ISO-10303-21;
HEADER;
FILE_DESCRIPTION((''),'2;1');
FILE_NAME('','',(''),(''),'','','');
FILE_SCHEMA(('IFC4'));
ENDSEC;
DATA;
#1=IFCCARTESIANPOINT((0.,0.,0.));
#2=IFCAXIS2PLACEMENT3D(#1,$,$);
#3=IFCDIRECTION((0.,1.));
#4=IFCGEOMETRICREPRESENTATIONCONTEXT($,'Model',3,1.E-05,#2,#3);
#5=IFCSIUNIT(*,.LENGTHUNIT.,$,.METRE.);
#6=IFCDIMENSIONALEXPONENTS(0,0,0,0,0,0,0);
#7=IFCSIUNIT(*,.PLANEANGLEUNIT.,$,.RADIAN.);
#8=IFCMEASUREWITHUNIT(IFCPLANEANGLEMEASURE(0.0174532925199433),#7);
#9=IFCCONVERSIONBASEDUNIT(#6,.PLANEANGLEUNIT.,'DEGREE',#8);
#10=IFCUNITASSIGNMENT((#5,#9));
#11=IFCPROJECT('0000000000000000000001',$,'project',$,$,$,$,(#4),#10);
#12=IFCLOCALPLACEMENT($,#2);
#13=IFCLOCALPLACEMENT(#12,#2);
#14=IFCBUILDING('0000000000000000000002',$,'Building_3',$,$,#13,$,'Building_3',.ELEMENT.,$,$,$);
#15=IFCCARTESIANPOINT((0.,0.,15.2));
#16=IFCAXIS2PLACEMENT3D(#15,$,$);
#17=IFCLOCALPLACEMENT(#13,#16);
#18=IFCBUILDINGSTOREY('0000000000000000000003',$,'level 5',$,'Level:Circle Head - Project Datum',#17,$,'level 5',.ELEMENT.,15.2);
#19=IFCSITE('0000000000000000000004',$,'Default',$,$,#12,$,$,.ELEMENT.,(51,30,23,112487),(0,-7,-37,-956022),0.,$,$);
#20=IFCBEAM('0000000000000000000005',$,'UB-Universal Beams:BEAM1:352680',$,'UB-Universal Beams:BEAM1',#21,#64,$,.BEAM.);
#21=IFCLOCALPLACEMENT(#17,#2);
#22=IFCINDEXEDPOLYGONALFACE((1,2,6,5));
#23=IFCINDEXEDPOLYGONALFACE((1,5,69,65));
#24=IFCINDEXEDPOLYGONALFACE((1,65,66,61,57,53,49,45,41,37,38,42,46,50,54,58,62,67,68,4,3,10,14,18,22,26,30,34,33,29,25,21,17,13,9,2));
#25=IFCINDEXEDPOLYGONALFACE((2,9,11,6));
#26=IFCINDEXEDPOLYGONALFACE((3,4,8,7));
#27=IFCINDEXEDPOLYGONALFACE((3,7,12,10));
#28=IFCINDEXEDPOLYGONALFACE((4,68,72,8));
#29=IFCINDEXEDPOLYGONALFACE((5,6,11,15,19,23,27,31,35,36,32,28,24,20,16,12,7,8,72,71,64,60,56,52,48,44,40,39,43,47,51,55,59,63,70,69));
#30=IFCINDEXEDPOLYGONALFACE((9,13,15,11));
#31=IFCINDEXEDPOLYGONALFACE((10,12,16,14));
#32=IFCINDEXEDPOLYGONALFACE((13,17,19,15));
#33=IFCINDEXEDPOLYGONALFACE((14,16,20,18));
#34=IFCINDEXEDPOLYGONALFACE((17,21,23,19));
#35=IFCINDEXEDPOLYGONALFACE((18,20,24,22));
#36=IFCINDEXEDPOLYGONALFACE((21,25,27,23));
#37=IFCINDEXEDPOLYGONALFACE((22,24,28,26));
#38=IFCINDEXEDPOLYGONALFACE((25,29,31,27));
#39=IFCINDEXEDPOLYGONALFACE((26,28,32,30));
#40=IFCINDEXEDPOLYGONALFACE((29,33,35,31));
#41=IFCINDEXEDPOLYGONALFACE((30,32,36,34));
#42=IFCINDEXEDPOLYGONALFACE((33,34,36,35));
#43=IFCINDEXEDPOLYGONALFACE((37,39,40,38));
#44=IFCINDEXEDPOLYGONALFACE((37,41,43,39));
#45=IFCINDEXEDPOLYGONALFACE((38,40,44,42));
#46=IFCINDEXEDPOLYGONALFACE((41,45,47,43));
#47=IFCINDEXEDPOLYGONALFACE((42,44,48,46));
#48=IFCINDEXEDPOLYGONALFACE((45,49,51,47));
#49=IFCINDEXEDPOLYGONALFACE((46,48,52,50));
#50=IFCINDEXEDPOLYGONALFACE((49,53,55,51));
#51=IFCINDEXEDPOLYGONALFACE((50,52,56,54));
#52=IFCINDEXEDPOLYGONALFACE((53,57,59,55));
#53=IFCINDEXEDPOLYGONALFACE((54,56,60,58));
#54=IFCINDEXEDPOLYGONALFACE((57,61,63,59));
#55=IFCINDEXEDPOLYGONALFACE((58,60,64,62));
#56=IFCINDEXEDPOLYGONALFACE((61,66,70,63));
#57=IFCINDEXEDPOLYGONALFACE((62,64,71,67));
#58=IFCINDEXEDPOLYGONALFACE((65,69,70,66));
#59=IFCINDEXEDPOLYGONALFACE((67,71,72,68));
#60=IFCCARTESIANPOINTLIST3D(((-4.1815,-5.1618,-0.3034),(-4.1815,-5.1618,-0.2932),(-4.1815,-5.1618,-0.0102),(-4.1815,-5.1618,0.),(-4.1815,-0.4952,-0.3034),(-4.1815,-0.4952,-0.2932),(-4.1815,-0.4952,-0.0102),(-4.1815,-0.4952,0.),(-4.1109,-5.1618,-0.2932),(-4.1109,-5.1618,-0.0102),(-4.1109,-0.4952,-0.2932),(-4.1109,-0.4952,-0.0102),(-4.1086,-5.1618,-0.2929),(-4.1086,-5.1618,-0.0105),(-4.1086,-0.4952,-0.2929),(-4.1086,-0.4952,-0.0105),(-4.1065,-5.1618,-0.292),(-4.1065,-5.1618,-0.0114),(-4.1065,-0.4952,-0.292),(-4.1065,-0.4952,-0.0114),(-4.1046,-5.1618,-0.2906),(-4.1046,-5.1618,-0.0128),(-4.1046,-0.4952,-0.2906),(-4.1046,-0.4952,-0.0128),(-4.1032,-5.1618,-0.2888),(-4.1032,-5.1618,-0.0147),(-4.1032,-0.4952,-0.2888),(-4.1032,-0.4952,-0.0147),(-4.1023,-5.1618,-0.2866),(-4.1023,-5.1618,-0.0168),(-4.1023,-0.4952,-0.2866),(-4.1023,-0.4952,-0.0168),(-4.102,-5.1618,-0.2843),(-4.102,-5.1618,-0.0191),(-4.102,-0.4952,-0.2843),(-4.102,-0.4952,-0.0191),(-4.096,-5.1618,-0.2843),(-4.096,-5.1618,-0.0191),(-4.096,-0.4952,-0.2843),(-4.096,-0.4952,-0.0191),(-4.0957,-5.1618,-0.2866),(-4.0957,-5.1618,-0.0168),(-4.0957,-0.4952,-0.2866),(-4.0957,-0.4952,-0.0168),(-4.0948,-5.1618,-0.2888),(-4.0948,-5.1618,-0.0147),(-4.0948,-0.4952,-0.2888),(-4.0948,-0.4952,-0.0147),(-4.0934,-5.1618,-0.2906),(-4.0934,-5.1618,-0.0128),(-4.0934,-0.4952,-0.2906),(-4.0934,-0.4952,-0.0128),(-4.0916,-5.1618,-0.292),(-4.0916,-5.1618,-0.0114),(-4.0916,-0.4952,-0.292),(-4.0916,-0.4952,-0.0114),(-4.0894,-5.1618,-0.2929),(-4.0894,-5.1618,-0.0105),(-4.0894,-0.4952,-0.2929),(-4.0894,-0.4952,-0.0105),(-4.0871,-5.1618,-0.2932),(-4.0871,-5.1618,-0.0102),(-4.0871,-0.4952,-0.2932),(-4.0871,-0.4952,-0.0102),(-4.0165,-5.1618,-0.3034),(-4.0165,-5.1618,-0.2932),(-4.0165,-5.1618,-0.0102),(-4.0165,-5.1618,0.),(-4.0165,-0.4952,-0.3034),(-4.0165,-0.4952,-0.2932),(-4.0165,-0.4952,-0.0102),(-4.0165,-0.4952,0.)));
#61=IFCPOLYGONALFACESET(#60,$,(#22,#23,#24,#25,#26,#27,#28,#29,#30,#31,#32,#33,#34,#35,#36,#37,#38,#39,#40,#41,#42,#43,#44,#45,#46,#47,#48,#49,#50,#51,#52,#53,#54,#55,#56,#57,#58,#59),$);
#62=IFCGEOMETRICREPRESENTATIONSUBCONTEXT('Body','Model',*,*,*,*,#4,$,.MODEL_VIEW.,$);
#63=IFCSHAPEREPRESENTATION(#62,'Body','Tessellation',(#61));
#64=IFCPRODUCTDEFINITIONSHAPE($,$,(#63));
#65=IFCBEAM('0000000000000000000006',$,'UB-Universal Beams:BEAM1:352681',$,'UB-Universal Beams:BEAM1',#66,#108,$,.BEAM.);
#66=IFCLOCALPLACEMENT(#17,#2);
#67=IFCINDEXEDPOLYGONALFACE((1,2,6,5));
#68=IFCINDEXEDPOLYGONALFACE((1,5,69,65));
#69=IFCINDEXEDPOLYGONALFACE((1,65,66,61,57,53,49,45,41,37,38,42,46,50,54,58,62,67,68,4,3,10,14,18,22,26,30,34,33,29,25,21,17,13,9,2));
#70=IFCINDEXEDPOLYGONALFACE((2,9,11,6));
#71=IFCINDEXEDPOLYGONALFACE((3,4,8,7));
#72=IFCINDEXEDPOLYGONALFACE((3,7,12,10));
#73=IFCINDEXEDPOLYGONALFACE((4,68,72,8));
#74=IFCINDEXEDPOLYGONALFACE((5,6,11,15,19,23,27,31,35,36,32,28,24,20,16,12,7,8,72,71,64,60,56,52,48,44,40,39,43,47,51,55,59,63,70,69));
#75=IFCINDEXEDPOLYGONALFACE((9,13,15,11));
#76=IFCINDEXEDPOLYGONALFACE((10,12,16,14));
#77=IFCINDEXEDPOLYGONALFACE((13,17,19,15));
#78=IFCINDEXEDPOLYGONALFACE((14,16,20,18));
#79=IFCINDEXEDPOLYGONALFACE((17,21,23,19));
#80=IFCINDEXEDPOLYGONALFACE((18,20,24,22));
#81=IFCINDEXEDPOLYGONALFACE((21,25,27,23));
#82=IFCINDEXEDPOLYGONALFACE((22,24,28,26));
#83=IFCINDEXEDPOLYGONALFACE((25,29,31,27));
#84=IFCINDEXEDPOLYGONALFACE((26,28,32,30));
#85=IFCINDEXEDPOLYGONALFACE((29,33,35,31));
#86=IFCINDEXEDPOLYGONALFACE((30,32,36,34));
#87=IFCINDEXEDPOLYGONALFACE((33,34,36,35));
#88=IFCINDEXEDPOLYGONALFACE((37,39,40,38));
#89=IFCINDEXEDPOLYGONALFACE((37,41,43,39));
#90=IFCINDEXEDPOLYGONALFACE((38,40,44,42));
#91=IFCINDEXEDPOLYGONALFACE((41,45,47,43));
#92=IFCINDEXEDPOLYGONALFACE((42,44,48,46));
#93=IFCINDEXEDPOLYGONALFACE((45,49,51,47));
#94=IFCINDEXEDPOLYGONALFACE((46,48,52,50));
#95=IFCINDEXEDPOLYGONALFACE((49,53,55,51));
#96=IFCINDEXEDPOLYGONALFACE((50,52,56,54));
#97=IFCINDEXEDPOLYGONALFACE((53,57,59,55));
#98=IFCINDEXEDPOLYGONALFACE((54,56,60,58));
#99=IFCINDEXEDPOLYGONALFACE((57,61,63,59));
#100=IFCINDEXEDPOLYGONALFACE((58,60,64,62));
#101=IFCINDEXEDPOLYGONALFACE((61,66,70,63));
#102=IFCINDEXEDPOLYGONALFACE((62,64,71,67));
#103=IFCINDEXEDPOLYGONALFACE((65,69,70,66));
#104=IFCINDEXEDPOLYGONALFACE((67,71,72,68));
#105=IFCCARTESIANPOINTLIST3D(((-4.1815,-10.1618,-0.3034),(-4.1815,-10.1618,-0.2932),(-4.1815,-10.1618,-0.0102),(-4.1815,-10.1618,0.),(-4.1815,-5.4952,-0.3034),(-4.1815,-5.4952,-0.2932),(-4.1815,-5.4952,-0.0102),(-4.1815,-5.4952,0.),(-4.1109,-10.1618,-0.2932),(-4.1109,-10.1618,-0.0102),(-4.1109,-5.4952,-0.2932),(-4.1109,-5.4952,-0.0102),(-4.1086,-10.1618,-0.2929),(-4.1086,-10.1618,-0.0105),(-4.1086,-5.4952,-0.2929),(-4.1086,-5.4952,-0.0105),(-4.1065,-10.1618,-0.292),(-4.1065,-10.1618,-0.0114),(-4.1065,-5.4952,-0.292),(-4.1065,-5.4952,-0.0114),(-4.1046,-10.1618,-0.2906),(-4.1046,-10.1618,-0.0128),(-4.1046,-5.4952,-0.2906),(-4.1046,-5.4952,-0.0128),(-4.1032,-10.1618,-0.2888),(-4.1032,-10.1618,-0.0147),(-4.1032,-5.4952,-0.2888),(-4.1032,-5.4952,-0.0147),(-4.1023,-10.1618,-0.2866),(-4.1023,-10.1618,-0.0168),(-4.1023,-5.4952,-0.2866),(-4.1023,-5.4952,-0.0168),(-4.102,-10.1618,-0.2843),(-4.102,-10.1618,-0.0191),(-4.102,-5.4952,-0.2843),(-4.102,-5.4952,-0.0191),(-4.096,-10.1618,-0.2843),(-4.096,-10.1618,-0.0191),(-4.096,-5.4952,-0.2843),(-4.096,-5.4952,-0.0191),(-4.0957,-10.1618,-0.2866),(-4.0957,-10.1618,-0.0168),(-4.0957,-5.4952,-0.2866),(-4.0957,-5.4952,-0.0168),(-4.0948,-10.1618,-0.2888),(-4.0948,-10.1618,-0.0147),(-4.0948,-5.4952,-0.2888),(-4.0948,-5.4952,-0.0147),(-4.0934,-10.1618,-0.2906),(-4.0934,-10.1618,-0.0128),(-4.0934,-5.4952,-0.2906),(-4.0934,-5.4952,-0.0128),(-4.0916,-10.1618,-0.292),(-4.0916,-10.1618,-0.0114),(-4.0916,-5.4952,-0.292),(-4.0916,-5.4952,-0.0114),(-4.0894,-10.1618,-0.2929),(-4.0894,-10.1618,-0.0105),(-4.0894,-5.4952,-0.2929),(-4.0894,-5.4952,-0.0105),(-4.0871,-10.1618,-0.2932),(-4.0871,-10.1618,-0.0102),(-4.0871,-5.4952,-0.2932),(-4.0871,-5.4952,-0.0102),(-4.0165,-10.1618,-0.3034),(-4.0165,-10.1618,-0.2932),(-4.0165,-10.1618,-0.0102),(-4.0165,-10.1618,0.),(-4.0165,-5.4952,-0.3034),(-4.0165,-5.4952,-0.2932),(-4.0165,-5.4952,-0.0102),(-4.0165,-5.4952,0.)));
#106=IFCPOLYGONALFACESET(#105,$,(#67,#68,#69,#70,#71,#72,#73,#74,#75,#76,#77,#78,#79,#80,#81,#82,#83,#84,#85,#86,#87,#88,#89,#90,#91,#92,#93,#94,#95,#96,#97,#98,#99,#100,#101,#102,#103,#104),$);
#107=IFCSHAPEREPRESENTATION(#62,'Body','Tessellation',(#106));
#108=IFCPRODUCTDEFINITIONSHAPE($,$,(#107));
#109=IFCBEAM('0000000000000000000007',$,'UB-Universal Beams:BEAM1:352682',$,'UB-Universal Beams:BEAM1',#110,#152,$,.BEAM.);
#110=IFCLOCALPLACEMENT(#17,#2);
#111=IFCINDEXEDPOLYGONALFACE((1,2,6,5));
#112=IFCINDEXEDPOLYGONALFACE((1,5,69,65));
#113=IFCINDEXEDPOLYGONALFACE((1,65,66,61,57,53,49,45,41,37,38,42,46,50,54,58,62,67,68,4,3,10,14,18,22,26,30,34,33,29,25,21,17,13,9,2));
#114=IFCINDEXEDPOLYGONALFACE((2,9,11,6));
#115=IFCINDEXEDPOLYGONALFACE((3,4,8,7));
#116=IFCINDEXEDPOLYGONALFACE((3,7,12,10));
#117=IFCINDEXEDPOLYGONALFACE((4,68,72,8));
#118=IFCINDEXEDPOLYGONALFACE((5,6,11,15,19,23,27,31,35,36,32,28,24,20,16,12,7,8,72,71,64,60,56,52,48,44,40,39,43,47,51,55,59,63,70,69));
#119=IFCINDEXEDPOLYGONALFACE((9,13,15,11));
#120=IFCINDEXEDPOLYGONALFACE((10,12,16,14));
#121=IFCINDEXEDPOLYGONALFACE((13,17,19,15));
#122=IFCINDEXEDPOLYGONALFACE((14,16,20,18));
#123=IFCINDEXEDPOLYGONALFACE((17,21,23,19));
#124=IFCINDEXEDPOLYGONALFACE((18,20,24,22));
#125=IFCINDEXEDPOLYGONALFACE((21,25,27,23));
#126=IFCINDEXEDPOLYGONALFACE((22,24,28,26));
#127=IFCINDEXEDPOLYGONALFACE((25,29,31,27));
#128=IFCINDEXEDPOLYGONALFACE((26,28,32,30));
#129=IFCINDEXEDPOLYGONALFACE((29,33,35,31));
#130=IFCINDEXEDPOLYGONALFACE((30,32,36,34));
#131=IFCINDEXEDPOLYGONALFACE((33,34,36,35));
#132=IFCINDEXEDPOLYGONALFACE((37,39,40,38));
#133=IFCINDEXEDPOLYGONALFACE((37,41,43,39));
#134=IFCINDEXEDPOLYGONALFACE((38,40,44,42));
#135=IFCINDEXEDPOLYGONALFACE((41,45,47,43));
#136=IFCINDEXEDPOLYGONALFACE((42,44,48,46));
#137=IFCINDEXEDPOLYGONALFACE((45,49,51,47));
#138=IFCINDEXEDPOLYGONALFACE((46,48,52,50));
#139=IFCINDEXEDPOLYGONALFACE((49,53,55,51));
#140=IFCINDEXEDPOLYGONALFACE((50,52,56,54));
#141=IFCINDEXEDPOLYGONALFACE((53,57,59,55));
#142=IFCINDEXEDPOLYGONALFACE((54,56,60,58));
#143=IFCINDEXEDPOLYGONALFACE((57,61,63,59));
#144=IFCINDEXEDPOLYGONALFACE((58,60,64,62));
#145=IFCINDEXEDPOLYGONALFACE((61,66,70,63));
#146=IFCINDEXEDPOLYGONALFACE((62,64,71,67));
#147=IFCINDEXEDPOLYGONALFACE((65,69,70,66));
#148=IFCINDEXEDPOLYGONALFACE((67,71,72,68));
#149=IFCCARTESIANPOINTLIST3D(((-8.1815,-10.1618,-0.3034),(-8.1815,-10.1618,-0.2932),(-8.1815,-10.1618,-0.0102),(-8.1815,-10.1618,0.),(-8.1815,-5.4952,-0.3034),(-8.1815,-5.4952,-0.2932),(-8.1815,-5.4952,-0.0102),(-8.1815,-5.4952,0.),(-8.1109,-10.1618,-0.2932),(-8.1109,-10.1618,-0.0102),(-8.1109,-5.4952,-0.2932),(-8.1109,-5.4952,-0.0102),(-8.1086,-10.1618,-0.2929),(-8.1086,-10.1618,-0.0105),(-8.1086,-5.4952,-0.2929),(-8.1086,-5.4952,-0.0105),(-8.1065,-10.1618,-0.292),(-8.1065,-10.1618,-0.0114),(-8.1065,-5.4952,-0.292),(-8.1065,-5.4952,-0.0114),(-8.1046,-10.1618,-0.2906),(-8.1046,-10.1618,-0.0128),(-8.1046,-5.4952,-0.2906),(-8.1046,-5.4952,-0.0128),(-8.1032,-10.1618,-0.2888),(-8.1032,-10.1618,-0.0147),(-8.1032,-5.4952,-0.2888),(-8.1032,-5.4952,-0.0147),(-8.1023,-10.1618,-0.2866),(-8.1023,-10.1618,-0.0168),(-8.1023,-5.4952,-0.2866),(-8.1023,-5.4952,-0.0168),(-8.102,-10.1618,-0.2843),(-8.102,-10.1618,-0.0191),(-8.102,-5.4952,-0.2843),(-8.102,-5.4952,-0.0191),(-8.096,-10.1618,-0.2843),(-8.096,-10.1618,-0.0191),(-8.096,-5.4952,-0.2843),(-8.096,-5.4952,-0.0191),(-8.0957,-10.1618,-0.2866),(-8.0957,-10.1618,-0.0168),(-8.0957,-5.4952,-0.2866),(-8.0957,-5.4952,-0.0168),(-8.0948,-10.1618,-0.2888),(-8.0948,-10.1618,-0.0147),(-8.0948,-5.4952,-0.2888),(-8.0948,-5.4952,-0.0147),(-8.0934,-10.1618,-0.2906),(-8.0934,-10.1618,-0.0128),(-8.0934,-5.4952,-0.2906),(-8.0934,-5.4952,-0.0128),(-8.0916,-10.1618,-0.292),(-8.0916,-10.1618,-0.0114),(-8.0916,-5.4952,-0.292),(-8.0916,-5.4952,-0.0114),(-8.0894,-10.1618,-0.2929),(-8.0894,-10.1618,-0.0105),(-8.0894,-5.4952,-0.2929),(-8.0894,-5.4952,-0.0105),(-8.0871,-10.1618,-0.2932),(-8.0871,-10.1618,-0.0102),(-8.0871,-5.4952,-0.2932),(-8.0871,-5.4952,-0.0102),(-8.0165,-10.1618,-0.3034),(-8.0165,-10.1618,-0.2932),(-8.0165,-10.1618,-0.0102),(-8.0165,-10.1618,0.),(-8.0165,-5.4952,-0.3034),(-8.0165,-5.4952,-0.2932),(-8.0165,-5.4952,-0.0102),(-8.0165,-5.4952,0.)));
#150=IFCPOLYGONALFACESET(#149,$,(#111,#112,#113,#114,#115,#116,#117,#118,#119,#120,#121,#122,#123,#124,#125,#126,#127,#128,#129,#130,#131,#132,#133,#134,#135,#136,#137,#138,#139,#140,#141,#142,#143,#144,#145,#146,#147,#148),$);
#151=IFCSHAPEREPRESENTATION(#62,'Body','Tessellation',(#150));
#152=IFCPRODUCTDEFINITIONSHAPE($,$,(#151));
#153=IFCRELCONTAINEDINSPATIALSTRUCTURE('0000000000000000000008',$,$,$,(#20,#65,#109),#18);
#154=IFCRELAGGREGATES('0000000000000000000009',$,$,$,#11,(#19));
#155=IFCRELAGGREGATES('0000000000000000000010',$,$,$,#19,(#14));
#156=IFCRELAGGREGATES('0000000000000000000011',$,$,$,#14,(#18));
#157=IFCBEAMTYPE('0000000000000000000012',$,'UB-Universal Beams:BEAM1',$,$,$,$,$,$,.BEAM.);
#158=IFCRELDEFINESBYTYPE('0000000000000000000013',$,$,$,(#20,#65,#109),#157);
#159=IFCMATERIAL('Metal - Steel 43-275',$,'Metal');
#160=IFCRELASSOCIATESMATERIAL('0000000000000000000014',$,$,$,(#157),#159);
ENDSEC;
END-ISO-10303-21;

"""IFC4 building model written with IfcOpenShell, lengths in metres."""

from ifc_helpers import new_model, entity, si_unit, converted_unit, direction, frame, frame_2d, origin, place, context, subcontext, project, spatial, polyline, circle_curve, parameter, trimmed, segment, composite_curve, outline, extrude, source, transform, mapped, material, material_profile, profile_set, type_object, type_shapes, element, save


model = new_model("IFC4")

# Units and contexts
model_context = context("Model", 3, precision=1e-05, world=origin(), true_north=direction((0.0, 1.0)))
body_context = subcontext(model_context, "Body", "Model", "MODEL_VIEW")
ifc_project = project(units=[si_unit("LENGTHUNIT", "METRE"), converted_unit("PLANEANGLEUNIT", "DEGREE", entity("IfcPlaneAngleMeasure", 0.0174532925199433), si_unit("PLANEANGLEUNIT", "RADIAN"), dimensions=[0, 0, 0, 0, 0, 0, 0])], contexts=[model_context])

# Site, building, storey
site_placement = place(None, origin())
site = spatial("IfcSite", under=ifc_project, at=site_placement, Name="Default", CompositionType="ELEMENT", RefLatitude=(51, 30, 23, 112487), RefLongitude=(0, -7, -37, -956022), RefElevation=0.0)
building_placement = place(site_placement, origin())
building = spatial("IfcBuilding", under=site, at=building_placement, Name="Building_3", LongName="Building_3", CompositionType="ELEMENT")
storey_placement = place(building_placement, frame((0.0, 0.0, 15.2)))
storey = spatial("IfcBuildingStorey", under=building, at=storey_placement, Name="level 5", ObjectType="Level:Circle Head - Project Datum", LongName="level 5", CompositionType="ELEMENT", Elevation=15.2)

# Beams
ifc_material_1 = material(Name="Metal - Steel 43-275", Category="Metal")
ifc_material_profile = material_profile(ifc_material_1, outline(composite_curve([segment(polyline([(-0.0825, -0.1415), (-0.0825, -0.1517)]), True, "CONTINUOUS"), segment(polyline([(-0.0825, -0.1517), (0.0825, -0.1517)]), True, "CONTINUOUS"), segment(polyline([(0.0825, -0.1517), (0.0825, -0.1415)]), True, "CONTINUOUS"), segment(polyline([(0.0825, -0.1415), (0.0119, -0.1415)]), True, "CONTINUOUS"), segment(trimmed(circle_curve(frame_2d((0.0119, -0.1326), x_axis=(1.0, 0.0)), 0.0089), [parameter(180.0)], [parameter(270.0)], True, "PARAMETER"), False, "CONTINUOUS"), segment(polyline([(0.003, -0.1326), (0.003, 0.1326)]), True, "CONTINUOUS"), segment(trimmed(circle_curve(frame_2d((0.0119, 0.1326), x_axis=(1.0, 0.0)), 0.0089), [parameter(90.0)], [parameter(180.0)], True, "PARAMETER"), False, "CONTINUOUS"), segment(polyline([(0.0119, 0.1415), (0.0825, 0.1415)]), True, "CONTINUOUS"), segment(polyline([(0.0825, 0.1415), (0.0825, 0.1517)]), True, "CONTINUOUS"), segment(polyline([(0.0825, 0.1517), (-0.0825, 0.1517)]), True, "CONTINUOUS"), segment(polyline([(-0.0825, 0.1517), (-0.0825, 0.1415)]), True, "CONTINUOUS"), segment(polyline([(-0.0825, 0.1415), (-0.0119, 0.1415)]), True, "CONTINUOUS"), segment(trimmed(circle_curve(frame_2d((-0.0119, 0.1326), x_axis=(1.0, 0.0)), 0.0089), [parameter(360.0)], [parameter(90.0)], True, "PARAMETER"), False, "CONTINUOUS"), segment(polyline([(-0.003, 0.1326), (-0.003, -0.1326)]), True, "CONTINUOUS"), segment(trimmed(circle_curve(frame_2d((-0.0119, -0.1326), x_axis=(1.0, 0.0)), 0.0089), [parameter(270.0)], [parameter(360.0)], True, "PARAMETER"), False, "CONTINUOUS"), segment(polyline([(-0.0119, -0.1415), (-0.0825, -0.1415)]), True, "CONTINUOUS")], self_intersect=False)), Name="BEAM1")
ifc_profile_set = profile_set([ifc_material_profile], Name="BEAM1")
beam_type_1 = type_object("IfcBeamType", Name="UB-Universal Beams:BEAM1", PredefinedType="BEAM", material=ifc_profile_set)
shared_shape_1 = source(origin(), body_context, "Body", "SweptSolid", [
    extrude(outline(composite_curve([segment(polyline([(-0.0825, -0.1415), (-0.0825, -0.1517)]), True, "CONTINUOUS"), segment(polyline([(-0.0825, -0.1517), (0.0825, -0.1517)]), True, "CONTINUOUS"), segment(polyline([(0.0825, -0.1517), (0.0825, -0.1415)]), True, "CONTINUOUS"), segment(polyline([(0.0825, -0.1415), (0.0119, -0.1415)]), True, "CONTINUOUS"), segment(trimmed(circle_curve(frame_2d((0.0119, -0.1326), x_axis=(0.0, -1.0)), 0.0089), [parameter(270.0)], [parameter(360.0)], True, "PARAMETER"), False, "CONTINUOUS"), segment(polyline([(0.003, -0.1326), (0.003, 0.1326)]), True, "CONTINUOUS"), segment(trimmed(circle_curve(frame_2d((0.0119, 0.1326), x_axis=(-1.0, 0.0)), 0.0089), [parameter(270.0)], [parameter(360.0)], True, "PARAMETER"), False, "CONTINUOUS"), segment(polyline([(0.0119, 0.1415), (0.0825, 0.1415)]), True, "CONTINUOUS"), segment(polyline([(0.0825, 0.1415), (0.0825, 0.1517)]), True, "CONTINUOUS"), segment(polyline([(0.0825, 0.1517), (-0.0825, 0.1517)]), True, "CONTINUOUS"), segment(polyline([(-0.0825, 0.1517), (-0.0825, 0.1415)]), True, "CONTINUOUS"), segment(polyline([(-0.0825, 0.1415), (-0.0119, 0.1415)]), True, "CONTINUOUS"), segment(trimmed(circle_curve(frame_2d((-0.0119, 0.1326), x_axis=(0.0, 1.0)), 0.0089), [parameter(270.0)], [parameter(360.0)], True, "PARAMETER"), False, "CONTINUOUS"), segment(polyline([(-0.003, 0.1326), (-0.003, -0.1326)]), True, "CONTINUOUS"), segment(trimmed(circle_curve(frame_2d((-0.0119, -0.1326), x_axis=(1.0, 0.0)), 0.0089), [parameter(270.0)], [parameter(0.0)], True, "PARAMETER"), False, "CONTINUOUS"), segment(polyline([(-0.0119, -0.1415), (-0.0825, -0.1415)]), True, "CONTINUOUS")], self_intersect=False)), frame((-2.3333, 0.0, 0.0), z_axis=(-1.0, 0.0, 0.0), x_axis=(0.0, -1.0, 0.0)), (0.0, 0.0, -1.0), 4.6666),
])
type_shapes(beam_type_1, [shared_shape_1])
for number, where, z_axis, x_axis, name in (
    (1, (-4.099, -2.8285, -0.1517), (0.0, 0.0, 1.0), (0.0, 1.0, 0.0), "UB-Universal Beams:BEAM1:352680"),
    (2, (-4.099, -7.8285, -0.1517), (0.0, 0.0, 1.0), (0.0, 1.0, 0.0), "UB-Universal Beams:BEAM1:352681"),
    (3, (-8.099, -7.8285, -0.1517), (0.0, 0.0, 1.0), (0.0, 1.0, 0.0), "UB-Universal Beams:BEAM1:352682"),
):
    element("IfcBeam", number, at=place(storey_placement, frame(where, z_axis=z_axis, x_axis=x_axis)), inside=storey, type_object=beam_type_1, Name=name, ObjectType="UB-Universal Beams:BEAM1", PredefinedType="BEAM", context=body_context, shape_type="MappedRepresentation", body=[
        mapped(shared_shape_1, transform((0.0, 0.0, 0.0), scale=1.0)),
    ])

save(model, "model.ifc")
